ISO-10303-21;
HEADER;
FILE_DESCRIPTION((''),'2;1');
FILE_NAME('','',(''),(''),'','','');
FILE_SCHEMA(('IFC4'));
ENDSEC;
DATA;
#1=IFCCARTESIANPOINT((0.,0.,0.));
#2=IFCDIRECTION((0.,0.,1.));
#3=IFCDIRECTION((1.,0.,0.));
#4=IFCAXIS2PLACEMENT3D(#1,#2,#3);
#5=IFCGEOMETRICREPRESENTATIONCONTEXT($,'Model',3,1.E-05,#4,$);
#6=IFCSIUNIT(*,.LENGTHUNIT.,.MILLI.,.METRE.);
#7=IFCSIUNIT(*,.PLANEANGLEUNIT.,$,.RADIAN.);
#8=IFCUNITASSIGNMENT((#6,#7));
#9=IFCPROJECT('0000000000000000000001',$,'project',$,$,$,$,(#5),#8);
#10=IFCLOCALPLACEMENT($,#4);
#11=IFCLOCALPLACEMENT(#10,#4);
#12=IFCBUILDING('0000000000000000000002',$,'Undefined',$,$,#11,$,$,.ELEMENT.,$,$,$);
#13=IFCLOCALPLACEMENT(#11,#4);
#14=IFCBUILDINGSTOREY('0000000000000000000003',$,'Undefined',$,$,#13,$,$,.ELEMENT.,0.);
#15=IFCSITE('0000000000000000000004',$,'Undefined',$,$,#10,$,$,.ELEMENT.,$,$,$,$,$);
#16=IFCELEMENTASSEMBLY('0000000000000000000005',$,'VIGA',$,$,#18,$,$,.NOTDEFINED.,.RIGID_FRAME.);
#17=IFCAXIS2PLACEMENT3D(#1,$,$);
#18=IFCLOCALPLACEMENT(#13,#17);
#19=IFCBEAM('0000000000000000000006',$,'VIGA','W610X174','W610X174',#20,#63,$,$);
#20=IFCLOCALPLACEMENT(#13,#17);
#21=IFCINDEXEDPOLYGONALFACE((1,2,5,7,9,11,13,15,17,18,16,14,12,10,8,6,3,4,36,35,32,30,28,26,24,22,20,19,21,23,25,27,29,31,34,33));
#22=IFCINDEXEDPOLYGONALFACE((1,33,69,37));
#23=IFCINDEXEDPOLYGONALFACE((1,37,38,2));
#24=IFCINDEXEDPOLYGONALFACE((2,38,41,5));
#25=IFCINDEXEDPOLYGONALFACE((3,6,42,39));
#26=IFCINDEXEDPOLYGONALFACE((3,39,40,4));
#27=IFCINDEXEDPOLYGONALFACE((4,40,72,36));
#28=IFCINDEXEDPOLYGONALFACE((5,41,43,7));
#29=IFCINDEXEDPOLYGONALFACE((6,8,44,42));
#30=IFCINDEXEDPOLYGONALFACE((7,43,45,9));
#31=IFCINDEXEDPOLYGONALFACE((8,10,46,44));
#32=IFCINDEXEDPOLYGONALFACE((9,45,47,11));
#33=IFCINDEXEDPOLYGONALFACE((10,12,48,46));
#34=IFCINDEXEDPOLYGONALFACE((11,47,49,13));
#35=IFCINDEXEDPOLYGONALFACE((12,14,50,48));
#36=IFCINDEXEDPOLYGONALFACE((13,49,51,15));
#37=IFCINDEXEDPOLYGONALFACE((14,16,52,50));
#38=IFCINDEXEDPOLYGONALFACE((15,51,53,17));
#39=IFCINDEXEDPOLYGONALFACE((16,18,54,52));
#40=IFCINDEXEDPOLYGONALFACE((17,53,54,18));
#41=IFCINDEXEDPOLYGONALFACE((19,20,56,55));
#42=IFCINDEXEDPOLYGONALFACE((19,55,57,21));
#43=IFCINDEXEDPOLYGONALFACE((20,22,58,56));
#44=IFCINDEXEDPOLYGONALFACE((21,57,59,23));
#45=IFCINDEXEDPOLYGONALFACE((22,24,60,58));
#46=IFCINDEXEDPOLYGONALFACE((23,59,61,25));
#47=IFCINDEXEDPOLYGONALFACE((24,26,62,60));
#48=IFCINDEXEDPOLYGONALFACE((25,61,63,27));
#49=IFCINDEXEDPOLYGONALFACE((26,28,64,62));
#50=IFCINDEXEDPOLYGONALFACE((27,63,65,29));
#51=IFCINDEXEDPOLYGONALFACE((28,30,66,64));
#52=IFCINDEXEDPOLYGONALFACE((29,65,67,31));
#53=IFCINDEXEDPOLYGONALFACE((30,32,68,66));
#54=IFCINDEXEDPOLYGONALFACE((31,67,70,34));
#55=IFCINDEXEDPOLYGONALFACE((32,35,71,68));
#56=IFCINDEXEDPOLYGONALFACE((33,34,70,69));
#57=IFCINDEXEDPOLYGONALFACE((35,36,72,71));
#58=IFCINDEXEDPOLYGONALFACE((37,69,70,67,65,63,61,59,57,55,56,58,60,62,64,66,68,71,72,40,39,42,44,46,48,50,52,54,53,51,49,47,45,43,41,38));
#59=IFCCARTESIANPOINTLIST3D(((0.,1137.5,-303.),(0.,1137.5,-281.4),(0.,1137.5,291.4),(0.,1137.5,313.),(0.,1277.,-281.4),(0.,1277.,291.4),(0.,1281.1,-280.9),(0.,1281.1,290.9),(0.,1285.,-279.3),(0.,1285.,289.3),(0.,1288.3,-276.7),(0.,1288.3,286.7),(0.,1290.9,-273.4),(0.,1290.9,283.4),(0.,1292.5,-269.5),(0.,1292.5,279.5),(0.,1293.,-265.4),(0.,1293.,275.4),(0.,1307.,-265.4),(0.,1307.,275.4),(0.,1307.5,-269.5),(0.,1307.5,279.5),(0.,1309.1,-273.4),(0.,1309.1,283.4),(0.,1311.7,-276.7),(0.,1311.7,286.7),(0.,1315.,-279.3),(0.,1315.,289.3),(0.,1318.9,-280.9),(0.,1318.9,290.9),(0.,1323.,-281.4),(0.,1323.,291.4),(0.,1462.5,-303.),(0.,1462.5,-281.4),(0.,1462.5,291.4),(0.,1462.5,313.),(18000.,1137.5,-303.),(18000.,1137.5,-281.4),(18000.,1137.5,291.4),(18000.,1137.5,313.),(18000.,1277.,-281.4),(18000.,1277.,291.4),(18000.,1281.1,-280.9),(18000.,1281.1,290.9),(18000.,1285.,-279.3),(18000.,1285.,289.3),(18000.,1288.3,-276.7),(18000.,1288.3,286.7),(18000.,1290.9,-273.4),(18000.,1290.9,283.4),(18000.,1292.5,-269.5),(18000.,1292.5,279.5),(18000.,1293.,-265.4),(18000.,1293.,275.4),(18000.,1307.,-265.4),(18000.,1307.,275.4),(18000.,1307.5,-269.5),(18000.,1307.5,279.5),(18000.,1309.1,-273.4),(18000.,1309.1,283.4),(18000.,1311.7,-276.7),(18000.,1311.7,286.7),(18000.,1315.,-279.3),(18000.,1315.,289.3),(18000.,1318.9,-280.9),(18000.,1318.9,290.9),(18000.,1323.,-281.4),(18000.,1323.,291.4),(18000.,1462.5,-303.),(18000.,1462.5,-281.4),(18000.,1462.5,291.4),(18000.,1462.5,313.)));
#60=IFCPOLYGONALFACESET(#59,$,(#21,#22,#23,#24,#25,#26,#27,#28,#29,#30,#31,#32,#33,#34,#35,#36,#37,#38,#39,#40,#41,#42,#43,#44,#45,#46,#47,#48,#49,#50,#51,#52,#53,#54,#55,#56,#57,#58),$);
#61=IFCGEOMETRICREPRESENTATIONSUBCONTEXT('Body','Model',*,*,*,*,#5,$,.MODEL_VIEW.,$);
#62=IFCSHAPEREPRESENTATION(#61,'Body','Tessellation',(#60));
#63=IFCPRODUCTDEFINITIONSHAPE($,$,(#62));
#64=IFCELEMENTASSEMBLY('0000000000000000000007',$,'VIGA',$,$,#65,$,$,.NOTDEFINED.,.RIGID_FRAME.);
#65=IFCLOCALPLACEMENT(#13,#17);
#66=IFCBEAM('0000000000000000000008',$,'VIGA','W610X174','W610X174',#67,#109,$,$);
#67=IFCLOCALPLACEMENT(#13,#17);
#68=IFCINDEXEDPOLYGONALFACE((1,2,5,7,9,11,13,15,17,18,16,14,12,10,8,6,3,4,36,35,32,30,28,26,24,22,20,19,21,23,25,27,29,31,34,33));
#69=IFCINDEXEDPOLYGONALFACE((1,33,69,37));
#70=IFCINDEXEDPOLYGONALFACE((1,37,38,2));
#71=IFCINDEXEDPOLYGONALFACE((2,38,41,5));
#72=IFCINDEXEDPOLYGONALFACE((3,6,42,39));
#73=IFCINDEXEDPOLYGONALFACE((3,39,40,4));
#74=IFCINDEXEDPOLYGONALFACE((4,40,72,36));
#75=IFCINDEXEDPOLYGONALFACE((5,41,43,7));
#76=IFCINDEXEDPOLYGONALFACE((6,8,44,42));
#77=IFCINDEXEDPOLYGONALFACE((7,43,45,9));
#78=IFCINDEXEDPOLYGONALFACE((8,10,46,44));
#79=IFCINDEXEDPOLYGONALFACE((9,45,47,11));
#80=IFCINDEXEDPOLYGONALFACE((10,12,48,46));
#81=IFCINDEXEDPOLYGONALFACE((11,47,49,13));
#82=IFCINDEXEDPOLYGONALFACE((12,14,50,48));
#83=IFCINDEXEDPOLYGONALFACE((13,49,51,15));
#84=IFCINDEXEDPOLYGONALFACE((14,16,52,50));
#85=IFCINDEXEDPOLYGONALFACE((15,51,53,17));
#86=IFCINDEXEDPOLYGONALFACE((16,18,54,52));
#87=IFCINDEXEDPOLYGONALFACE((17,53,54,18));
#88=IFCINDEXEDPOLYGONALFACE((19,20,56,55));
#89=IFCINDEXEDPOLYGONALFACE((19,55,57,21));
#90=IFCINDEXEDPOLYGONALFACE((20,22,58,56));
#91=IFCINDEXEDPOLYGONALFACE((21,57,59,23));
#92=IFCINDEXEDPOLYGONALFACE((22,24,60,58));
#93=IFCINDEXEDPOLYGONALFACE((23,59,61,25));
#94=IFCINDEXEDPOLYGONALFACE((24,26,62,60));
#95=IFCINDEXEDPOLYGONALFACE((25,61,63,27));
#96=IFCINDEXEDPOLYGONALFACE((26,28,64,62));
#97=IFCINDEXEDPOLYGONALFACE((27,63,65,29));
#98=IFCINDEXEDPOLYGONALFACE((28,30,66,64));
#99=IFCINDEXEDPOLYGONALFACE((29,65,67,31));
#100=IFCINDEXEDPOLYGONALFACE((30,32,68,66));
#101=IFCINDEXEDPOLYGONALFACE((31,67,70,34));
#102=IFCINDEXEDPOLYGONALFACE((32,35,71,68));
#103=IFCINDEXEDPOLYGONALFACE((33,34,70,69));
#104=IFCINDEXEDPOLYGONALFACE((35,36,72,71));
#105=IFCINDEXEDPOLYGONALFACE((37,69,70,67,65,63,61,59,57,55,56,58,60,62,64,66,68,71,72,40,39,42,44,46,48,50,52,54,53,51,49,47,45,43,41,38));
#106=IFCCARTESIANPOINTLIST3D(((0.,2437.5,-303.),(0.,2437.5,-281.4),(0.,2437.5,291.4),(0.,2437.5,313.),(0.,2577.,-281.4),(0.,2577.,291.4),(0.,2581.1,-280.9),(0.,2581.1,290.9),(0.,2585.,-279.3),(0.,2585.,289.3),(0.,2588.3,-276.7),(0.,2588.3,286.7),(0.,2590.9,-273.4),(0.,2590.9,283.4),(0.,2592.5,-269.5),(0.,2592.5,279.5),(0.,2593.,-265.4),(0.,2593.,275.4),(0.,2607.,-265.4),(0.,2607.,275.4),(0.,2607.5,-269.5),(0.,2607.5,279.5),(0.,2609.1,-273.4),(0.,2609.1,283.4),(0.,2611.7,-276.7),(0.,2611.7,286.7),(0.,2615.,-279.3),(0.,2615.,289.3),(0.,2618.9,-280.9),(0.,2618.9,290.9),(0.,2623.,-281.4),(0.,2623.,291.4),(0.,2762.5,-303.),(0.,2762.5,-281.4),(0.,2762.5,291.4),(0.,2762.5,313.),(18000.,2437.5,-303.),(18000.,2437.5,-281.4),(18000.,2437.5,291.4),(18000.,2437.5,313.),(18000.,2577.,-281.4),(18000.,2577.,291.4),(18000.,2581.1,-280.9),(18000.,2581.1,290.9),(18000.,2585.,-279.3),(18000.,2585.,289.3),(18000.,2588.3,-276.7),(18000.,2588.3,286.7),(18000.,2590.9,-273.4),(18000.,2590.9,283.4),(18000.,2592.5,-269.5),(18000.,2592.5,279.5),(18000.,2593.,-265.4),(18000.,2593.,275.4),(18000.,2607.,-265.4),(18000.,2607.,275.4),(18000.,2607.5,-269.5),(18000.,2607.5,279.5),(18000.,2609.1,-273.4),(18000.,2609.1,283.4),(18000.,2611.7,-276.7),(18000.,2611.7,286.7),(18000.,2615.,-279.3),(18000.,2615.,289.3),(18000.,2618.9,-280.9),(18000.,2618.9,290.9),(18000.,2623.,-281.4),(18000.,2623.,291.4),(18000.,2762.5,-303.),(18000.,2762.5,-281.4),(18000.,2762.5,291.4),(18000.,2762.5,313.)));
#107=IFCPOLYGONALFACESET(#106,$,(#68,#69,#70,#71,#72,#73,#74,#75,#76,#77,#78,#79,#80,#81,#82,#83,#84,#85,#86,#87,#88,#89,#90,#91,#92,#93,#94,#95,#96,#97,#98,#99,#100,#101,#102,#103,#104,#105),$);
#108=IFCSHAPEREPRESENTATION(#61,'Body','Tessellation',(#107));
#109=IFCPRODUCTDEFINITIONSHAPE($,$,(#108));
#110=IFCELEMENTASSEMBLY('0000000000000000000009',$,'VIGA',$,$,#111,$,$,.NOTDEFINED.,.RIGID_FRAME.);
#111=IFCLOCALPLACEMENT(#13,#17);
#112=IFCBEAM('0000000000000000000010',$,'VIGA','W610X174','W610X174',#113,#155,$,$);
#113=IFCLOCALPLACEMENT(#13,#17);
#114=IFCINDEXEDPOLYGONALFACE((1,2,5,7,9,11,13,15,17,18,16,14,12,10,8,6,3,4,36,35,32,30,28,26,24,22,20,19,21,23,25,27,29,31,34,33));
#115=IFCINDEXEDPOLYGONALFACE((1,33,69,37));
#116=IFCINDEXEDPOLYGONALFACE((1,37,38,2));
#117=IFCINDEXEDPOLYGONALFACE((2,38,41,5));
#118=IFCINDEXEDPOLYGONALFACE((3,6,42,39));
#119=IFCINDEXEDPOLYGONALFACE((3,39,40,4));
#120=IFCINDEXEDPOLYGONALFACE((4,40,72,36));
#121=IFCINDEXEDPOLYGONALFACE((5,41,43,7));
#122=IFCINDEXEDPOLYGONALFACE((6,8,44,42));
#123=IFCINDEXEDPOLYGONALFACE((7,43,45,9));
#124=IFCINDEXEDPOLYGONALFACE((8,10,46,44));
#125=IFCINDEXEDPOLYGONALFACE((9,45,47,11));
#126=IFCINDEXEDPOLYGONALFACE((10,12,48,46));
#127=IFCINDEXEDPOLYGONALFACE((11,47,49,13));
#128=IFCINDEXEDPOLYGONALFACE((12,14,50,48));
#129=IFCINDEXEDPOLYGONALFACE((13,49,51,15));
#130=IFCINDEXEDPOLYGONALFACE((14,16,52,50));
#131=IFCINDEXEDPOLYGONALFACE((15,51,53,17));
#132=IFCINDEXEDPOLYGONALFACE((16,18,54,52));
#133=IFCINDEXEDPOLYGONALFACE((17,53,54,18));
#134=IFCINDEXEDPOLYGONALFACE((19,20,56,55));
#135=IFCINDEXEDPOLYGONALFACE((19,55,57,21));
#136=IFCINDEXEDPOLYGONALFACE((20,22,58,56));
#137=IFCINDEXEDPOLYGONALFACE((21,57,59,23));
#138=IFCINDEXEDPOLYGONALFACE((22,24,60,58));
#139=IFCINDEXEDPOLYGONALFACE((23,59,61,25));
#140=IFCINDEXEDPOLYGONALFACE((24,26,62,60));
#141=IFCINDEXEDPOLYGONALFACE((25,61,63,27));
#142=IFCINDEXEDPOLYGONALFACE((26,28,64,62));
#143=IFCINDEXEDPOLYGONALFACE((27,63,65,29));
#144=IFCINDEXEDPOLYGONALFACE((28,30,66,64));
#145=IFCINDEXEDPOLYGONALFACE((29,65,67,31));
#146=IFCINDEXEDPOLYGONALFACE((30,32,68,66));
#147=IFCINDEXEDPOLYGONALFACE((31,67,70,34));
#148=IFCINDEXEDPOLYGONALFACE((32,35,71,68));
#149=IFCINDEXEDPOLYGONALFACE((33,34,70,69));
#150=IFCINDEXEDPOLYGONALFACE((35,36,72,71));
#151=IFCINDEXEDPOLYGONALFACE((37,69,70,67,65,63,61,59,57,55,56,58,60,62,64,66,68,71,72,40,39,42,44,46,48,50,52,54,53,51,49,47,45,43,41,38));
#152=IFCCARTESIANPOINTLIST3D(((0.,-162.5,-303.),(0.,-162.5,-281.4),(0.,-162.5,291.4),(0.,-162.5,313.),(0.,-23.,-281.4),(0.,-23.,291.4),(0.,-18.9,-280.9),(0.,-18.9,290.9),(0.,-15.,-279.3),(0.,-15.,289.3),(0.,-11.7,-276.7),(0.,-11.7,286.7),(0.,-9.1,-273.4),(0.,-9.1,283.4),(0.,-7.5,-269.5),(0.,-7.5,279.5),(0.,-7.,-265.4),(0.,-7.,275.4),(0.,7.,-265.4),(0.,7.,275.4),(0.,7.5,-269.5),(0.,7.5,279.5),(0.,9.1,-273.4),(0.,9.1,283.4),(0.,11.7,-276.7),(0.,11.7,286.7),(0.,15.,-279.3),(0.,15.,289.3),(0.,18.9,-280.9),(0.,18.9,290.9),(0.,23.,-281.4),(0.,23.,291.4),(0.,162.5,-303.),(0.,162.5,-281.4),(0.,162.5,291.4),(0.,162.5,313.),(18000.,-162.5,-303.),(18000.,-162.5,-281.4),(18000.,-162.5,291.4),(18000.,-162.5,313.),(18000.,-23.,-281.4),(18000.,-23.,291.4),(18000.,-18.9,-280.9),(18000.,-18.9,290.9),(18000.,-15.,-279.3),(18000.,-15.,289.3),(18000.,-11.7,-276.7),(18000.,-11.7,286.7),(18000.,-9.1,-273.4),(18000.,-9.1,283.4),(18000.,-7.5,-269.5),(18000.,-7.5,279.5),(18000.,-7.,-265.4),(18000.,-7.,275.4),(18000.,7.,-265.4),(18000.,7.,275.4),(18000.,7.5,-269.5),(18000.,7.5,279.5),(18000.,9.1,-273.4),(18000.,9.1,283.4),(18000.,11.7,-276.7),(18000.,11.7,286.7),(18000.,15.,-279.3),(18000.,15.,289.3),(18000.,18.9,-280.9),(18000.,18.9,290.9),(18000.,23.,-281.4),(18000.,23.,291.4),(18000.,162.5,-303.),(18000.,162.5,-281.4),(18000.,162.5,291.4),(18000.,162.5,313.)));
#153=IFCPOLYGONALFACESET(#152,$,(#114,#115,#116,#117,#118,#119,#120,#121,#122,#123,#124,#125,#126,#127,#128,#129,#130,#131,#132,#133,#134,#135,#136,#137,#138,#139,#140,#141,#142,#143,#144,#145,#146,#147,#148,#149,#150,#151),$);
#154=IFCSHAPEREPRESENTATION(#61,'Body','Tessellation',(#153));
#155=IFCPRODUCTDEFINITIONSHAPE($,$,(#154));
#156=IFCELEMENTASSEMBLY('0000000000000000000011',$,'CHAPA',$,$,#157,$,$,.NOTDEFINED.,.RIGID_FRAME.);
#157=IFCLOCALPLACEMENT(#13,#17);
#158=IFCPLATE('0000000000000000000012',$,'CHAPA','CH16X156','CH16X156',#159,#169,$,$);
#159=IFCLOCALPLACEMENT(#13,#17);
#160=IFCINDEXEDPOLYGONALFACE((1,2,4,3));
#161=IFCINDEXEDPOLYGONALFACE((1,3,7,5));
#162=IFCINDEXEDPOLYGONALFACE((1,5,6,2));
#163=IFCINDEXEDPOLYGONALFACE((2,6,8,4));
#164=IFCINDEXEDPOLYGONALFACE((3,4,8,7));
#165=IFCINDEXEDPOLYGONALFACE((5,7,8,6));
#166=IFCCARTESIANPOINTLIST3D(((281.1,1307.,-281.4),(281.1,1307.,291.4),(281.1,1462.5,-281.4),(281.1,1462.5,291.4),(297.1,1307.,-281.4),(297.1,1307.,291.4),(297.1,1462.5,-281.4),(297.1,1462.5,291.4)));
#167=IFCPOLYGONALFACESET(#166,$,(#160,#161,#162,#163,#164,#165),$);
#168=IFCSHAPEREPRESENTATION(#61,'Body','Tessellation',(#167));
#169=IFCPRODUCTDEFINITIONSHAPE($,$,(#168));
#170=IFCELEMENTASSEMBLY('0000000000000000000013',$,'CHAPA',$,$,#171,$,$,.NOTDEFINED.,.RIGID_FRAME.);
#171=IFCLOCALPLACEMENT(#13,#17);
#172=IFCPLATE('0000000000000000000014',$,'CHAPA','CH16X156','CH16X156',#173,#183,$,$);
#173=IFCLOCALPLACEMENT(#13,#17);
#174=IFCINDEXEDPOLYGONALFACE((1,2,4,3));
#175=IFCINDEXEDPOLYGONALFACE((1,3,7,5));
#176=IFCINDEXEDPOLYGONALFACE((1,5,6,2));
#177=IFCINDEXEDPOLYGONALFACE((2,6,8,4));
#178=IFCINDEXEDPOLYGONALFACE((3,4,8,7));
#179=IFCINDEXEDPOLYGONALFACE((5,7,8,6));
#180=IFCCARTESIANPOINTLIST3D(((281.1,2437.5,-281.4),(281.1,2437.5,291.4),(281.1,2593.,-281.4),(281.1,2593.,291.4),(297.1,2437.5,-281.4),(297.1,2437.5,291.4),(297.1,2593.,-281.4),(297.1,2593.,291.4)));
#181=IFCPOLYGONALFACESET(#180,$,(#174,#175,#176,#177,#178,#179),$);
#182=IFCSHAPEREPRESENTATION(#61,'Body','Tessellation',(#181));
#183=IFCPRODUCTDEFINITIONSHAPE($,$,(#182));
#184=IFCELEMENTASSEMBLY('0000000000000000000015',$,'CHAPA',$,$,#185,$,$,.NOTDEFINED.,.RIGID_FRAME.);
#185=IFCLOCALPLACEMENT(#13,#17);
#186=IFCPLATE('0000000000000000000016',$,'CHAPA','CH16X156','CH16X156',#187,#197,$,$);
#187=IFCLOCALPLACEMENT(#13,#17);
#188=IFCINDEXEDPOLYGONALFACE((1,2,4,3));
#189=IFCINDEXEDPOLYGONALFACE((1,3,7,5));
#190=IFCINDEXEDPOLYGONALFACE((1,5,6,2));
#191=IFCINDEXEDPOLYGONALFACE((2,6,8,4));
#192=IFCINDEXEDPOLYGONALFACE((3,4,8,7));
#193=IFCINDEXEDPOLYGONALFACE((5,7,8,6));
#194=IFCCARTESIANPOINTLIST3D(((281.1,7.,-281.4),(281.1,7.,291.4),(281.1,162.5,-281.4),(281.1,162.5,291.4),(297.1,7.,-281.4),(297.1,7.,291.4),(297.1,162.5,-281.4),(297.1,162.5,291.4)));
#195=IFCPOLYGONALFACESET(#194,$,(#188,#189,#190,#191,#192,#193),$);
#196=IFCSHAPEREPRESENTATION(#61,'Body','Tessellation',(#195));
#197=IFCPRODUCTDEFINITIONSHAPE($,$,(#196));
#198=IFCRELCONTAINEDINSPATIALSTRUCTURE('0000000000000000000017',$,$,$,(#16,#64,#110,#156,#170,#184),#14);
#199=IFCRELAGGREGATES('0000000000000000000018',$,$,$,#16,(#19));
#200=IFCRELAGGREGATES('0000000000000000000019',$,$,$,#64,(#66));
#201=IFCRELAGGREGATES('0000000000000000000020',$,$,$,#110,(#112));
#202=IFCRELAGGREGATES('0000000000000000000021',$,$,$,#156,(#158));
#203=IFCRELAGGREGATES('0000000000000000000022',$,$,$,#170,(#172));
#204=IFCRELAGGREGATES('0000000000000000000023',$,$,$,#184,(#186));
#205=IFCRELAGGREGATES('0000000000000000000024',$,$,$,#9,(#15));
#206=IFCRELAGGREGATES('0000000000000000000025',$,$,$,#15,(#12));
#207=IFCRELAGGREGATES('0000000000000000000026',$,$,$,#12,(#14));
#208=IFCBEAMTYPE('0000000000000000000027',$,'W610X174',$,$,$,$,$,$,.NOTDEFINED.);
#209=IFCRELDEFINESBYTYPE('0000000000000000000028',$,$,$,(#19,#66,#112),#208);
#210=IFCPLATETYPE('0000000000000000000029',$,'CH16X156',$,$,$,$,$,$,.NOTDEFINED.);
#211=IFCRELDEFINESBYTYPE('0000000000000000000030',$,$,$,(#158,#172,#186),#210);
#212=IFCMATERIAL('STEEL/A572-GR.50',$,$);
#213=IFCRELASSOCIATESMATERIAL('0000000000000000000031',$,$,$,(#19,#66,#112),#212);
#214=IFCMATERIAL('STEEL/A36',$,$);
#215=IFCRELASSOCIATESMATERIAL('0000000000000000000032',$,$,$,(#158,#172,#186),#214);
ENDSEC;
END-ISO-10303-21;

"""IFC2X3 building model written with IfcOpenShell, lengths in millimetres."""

from ifc_helpers import new_model, si_unit, frame, origin_with_axes, origin_2d_with_axis, place, context, subcontext, project, spatial, polyline, i_section, outline, extrude, material, type_object, element, aggregate, save


model = new_model("IFC2X3")

# Units and contexts
model_context = context("Model", 3, precision=1e-05, world=origin_with_axes())
body_context = subcontext(model_context, "Body", "Model", "MODEL_VIEW")
ifc_project = project(units=[si_unit("LENGTHUNIT", "METRE", prefix="MILLI"), si_unit("PLANEANGLEUNIT", "RADIAN")], contexts=[model_context])

# Site, building, storey
site_placement = place(None, origin_with_axes())
site = spatial("IfcSite", under=ifc_project, at=site_placement, Name="Undefined", CompositionType="ELEMENT")
building_placement = place(site_placement, origin_with_axes())
building = spatial("IfcBuilding", under=site, at=building_placement, Name="Undefined", CompositionType="ELEMENT")
storey_placement = place(building_placement, origin_with_axes())
storey = spatial("IfcBuildingStorey", under=building, at=storey_placement, Name="Undefined", CompositionType="ELEMENT", Elevation=0.0)

# Element assemblies, beams
ifc_material_1 = material(Name="STEEL/A572-GR.50")
assembly_1_placement = place(storey_placement, origin_with_axes())
assembly_1 = element("IfcElementAssembly", 1, at=assembly_1_placement, inside=storey, Name="VIGA", AssemblyPlace="NOTDEFINED", PredefinedType="RIGID_FRAME")
beam_type_1 = type_object("IfcBeamType", Name="W610X174", PredefinedType="NOTDEFINED")
beam_1_placement = place(assembly_1_placement, frame((0.0, 1300.0, 5.0), z_axis=(0.0, 0.0, 1.0), x_axis=(1.0, 0.0, 0.0)))
beam_1 = element("IfcBeam", 2, at=beam_1_placement, type_object=beam_type_1, material=ifc_material_1, Name="VIGA", Description="W610X174", ObjectType="W610X174", context=body_context, shape_type="SweptSolid", body=[
    extrude(i_section(OverallWidth=325.0, OverallDepth=616.0, WebThickness=14.0, FlangeThickness=21.6, FilletRadius=16.0, at=origin_2d_with_axis()), frame((18000.0, 0.0, 0.0), z_axis=(-1.0, 0.0, 0.0), x_axis=(0.0, -1.0, 0.0)), (0.0, 0.0, 1.0), 18000.0),
])
aggregate(assembly_1, [beam_1])
assembly_2_placement = place(storey_placement, origin_with_axes())
assembly_2 = element("IfcElementAssembly", 3, at=assembly_2_placement, inside=storey, Name="VIGA", AssemblyPlace="NOTDEFINED", PredefinedType="RIGID_FRAME")
beam_2_placement = place(assembly_2_placement, frame((0.0, 2600.0, 5.0), z_axis=(0.0, 0.0, 1.0), x_axis=(1.0, 0.0, 0.0)))
beam_2 = element("IfcBeam", 4, at=beam_2_placement, type_object=beam_type_1, material=ifc_material_1, Name="VIGA", Description="W610X174", ObjectType="W610X174", context=body_context, shape_type="SweptSolid", body=[
    extrude(i_section(OverallWidth=325.0, OverallDepth=616.0, WebThickness=14.0, FlangeThickness=21.6, FilletRadius=16.0, at=origin_2d_with_axis()), frame((18000.0, 0.0, 0.0), z_axis=(-1.0, 0.0, 0.0), x_axis=(0.0, -1.0, 0.0)), (0.0, 0.0, 1.0), 18000.0),
])
aggregate(assembly_2, [beam_2])
assembly_3_placement = place(storey_placement, origin_with_axes())
assembly_3 = element("IfcElementAssembly", 5, at=assembly_3_placement, inside=storey, Name="VIGA", AssemblyPlace="NOTDEFINED", PredefinedType="RIGID_FRAME")
beam_3_placement = place(assembly_3_placement, frame((0.0, 0.0, 5.0), z_axis=(0.0, 0.0, 1.0), x_axis=(1.0, 0.0, 0.0)))
beam_3 = element("IfcBeam", 6, at=beam_3_placement, type_object=beam_type_1, material=ifc_material_1, Name="VIGA", Description="W610X174", ObjectType="W610X174", context=body_context, shape_type="SweptSolid", body=[
    extrude(i_section(OverallWidth=325.0, OverallDepth=616.0, WebThickness=14.0, FlangeThickness=21.6, FilletRadius=16.0, at=origin_2d_with_axis()), frame((18000.0, 0.0, 0.0), z_axis=(-1.0, 0.0, 0.0), x_axis=(0.0, -1.0, 0.0)), (0.0, 0.0, 1.0), 18000.0),
])
aggregate(assembly_3, [beam_3])

# Element assemblies, plates
assembly_4_placement = place(storey_placement, origin_with_axes())
assembly_4 = element("IfcElementAssembly", 7, at=assembly_4_placement, inside=storey, Name="CHAPA", AssemblyPlace="NOTDEFINED", PredefinedType="RIGID_FRAME")
ifc_material_2 = material(Name="STEEL/A36")
plate_type = type_object("IfcPlateType", Name="CH16X156", PredefinedType="NOTDEFINED")
plate_1_placement = place(assembly_4_placement, frame((289.1, 1462.5, 291.4), z_axis=(1.0, 0.0, 0.0), x_axis=(0.0, -1.0, 0.0)))
plate_1 = element("IfcPlate", 8, at=plate_1_placement, type_object=plate_type, material=ifc_material_2, Name="CHAPA", Description="CH16X156", ObjectType="CH16X156", context=body_context, shape_type="SweptSolid", body=[
    extrude(outline(polyline([(0.0, 0.0), (155.5, 0.0), (155.5, 572.8), (0.0, 572.8), (0.0, 0.0)])), frame((0.0, 0.0, -8.0), z_axis=(0.0, 0.0, 1.0), x_axis=(1.0, 0.0, 0.0)), (0.0, 0.0, 1.0), 16.0),
])
aggregate(assembly_4, [plate_1])
assembly_5_placement = place(storey_placement, origin_with_axes())
assembly_5 = element("IfcElementAssembly", 9, at=assembly_5_placement, inside=storey, Name="CHAPA", AssemblyPlace="NOTDEFINED", PredefinedType="RIGID_FRAME")
plate_2_placement = place(assembly_5_placement, frame((289.1, 2593.0, 291.4), z_axis=(1.0, 0.0, 0.0), x_axis=(0.0, -1.0, 0.0)))
plate_2 = element("IfcPlate", 10, at=plate_2_placement, type_object=plate_type, material=ifc_material_2, Name="CHAPA", Description="CH16X156", ObjectType="CH16X156", context=body_context, shape_type="SweptSolid", body=[
    extrude(outline(polyline([(0.0, 0.0), (155.5, 0.0), (155.5, 572.8), (0.0, 572.8), (0.0, 0.0)])), frame((0.0, 0.0, -8.0), z_axis=(0.0, 0.0, 1.0), x_axis=(1.0, 0.0, 0.0)), (0.0, 0.0, 1.0), 16.0),
])
aggregate(assembly_5, [plate_2])
assembly_6_placement = place(storey_placement, origin_with_axes())
assembly_6 = element("IfcElementAssembly", 11, at=assembly_6_placement, inside=storey, Name="CHAPA", AssemblyPlace="NOTDEFINED", PredefinedType="RIGID_FRAME")
plate_3_placement = place(assembly_6_placement, frame((289.1, 162.5, 291.4), z_axis=(1.0, 0.0, 0.0), x_axis=(0.0, -1.0, 0.0)))
plate_3 = element("IfcPlate", 12, at=plate_3_placement, type_object=plate_type, material=ifc_material_2, Name="CHAPA", Description="CH16X156", ObjectType="CH16X156", context=body_context, shape_type="SweptSolid", body=[
    extrude(outline(polyline([(0.0, 0.0), (155.5, 0.0), (155.5, 572.8), (0.0, 572.8), (0.0, 0.0)])), frame((0.0, 0.0, -8.0), z_axis=(0.0, 0.0, 1.0), x_axis=(1.0, 0.0, 0.0)), (0.0, 0.0, 1.0), 16.0),
])
aggregate(assembly_6, [plate_3])

save(model, "model.ifc")
